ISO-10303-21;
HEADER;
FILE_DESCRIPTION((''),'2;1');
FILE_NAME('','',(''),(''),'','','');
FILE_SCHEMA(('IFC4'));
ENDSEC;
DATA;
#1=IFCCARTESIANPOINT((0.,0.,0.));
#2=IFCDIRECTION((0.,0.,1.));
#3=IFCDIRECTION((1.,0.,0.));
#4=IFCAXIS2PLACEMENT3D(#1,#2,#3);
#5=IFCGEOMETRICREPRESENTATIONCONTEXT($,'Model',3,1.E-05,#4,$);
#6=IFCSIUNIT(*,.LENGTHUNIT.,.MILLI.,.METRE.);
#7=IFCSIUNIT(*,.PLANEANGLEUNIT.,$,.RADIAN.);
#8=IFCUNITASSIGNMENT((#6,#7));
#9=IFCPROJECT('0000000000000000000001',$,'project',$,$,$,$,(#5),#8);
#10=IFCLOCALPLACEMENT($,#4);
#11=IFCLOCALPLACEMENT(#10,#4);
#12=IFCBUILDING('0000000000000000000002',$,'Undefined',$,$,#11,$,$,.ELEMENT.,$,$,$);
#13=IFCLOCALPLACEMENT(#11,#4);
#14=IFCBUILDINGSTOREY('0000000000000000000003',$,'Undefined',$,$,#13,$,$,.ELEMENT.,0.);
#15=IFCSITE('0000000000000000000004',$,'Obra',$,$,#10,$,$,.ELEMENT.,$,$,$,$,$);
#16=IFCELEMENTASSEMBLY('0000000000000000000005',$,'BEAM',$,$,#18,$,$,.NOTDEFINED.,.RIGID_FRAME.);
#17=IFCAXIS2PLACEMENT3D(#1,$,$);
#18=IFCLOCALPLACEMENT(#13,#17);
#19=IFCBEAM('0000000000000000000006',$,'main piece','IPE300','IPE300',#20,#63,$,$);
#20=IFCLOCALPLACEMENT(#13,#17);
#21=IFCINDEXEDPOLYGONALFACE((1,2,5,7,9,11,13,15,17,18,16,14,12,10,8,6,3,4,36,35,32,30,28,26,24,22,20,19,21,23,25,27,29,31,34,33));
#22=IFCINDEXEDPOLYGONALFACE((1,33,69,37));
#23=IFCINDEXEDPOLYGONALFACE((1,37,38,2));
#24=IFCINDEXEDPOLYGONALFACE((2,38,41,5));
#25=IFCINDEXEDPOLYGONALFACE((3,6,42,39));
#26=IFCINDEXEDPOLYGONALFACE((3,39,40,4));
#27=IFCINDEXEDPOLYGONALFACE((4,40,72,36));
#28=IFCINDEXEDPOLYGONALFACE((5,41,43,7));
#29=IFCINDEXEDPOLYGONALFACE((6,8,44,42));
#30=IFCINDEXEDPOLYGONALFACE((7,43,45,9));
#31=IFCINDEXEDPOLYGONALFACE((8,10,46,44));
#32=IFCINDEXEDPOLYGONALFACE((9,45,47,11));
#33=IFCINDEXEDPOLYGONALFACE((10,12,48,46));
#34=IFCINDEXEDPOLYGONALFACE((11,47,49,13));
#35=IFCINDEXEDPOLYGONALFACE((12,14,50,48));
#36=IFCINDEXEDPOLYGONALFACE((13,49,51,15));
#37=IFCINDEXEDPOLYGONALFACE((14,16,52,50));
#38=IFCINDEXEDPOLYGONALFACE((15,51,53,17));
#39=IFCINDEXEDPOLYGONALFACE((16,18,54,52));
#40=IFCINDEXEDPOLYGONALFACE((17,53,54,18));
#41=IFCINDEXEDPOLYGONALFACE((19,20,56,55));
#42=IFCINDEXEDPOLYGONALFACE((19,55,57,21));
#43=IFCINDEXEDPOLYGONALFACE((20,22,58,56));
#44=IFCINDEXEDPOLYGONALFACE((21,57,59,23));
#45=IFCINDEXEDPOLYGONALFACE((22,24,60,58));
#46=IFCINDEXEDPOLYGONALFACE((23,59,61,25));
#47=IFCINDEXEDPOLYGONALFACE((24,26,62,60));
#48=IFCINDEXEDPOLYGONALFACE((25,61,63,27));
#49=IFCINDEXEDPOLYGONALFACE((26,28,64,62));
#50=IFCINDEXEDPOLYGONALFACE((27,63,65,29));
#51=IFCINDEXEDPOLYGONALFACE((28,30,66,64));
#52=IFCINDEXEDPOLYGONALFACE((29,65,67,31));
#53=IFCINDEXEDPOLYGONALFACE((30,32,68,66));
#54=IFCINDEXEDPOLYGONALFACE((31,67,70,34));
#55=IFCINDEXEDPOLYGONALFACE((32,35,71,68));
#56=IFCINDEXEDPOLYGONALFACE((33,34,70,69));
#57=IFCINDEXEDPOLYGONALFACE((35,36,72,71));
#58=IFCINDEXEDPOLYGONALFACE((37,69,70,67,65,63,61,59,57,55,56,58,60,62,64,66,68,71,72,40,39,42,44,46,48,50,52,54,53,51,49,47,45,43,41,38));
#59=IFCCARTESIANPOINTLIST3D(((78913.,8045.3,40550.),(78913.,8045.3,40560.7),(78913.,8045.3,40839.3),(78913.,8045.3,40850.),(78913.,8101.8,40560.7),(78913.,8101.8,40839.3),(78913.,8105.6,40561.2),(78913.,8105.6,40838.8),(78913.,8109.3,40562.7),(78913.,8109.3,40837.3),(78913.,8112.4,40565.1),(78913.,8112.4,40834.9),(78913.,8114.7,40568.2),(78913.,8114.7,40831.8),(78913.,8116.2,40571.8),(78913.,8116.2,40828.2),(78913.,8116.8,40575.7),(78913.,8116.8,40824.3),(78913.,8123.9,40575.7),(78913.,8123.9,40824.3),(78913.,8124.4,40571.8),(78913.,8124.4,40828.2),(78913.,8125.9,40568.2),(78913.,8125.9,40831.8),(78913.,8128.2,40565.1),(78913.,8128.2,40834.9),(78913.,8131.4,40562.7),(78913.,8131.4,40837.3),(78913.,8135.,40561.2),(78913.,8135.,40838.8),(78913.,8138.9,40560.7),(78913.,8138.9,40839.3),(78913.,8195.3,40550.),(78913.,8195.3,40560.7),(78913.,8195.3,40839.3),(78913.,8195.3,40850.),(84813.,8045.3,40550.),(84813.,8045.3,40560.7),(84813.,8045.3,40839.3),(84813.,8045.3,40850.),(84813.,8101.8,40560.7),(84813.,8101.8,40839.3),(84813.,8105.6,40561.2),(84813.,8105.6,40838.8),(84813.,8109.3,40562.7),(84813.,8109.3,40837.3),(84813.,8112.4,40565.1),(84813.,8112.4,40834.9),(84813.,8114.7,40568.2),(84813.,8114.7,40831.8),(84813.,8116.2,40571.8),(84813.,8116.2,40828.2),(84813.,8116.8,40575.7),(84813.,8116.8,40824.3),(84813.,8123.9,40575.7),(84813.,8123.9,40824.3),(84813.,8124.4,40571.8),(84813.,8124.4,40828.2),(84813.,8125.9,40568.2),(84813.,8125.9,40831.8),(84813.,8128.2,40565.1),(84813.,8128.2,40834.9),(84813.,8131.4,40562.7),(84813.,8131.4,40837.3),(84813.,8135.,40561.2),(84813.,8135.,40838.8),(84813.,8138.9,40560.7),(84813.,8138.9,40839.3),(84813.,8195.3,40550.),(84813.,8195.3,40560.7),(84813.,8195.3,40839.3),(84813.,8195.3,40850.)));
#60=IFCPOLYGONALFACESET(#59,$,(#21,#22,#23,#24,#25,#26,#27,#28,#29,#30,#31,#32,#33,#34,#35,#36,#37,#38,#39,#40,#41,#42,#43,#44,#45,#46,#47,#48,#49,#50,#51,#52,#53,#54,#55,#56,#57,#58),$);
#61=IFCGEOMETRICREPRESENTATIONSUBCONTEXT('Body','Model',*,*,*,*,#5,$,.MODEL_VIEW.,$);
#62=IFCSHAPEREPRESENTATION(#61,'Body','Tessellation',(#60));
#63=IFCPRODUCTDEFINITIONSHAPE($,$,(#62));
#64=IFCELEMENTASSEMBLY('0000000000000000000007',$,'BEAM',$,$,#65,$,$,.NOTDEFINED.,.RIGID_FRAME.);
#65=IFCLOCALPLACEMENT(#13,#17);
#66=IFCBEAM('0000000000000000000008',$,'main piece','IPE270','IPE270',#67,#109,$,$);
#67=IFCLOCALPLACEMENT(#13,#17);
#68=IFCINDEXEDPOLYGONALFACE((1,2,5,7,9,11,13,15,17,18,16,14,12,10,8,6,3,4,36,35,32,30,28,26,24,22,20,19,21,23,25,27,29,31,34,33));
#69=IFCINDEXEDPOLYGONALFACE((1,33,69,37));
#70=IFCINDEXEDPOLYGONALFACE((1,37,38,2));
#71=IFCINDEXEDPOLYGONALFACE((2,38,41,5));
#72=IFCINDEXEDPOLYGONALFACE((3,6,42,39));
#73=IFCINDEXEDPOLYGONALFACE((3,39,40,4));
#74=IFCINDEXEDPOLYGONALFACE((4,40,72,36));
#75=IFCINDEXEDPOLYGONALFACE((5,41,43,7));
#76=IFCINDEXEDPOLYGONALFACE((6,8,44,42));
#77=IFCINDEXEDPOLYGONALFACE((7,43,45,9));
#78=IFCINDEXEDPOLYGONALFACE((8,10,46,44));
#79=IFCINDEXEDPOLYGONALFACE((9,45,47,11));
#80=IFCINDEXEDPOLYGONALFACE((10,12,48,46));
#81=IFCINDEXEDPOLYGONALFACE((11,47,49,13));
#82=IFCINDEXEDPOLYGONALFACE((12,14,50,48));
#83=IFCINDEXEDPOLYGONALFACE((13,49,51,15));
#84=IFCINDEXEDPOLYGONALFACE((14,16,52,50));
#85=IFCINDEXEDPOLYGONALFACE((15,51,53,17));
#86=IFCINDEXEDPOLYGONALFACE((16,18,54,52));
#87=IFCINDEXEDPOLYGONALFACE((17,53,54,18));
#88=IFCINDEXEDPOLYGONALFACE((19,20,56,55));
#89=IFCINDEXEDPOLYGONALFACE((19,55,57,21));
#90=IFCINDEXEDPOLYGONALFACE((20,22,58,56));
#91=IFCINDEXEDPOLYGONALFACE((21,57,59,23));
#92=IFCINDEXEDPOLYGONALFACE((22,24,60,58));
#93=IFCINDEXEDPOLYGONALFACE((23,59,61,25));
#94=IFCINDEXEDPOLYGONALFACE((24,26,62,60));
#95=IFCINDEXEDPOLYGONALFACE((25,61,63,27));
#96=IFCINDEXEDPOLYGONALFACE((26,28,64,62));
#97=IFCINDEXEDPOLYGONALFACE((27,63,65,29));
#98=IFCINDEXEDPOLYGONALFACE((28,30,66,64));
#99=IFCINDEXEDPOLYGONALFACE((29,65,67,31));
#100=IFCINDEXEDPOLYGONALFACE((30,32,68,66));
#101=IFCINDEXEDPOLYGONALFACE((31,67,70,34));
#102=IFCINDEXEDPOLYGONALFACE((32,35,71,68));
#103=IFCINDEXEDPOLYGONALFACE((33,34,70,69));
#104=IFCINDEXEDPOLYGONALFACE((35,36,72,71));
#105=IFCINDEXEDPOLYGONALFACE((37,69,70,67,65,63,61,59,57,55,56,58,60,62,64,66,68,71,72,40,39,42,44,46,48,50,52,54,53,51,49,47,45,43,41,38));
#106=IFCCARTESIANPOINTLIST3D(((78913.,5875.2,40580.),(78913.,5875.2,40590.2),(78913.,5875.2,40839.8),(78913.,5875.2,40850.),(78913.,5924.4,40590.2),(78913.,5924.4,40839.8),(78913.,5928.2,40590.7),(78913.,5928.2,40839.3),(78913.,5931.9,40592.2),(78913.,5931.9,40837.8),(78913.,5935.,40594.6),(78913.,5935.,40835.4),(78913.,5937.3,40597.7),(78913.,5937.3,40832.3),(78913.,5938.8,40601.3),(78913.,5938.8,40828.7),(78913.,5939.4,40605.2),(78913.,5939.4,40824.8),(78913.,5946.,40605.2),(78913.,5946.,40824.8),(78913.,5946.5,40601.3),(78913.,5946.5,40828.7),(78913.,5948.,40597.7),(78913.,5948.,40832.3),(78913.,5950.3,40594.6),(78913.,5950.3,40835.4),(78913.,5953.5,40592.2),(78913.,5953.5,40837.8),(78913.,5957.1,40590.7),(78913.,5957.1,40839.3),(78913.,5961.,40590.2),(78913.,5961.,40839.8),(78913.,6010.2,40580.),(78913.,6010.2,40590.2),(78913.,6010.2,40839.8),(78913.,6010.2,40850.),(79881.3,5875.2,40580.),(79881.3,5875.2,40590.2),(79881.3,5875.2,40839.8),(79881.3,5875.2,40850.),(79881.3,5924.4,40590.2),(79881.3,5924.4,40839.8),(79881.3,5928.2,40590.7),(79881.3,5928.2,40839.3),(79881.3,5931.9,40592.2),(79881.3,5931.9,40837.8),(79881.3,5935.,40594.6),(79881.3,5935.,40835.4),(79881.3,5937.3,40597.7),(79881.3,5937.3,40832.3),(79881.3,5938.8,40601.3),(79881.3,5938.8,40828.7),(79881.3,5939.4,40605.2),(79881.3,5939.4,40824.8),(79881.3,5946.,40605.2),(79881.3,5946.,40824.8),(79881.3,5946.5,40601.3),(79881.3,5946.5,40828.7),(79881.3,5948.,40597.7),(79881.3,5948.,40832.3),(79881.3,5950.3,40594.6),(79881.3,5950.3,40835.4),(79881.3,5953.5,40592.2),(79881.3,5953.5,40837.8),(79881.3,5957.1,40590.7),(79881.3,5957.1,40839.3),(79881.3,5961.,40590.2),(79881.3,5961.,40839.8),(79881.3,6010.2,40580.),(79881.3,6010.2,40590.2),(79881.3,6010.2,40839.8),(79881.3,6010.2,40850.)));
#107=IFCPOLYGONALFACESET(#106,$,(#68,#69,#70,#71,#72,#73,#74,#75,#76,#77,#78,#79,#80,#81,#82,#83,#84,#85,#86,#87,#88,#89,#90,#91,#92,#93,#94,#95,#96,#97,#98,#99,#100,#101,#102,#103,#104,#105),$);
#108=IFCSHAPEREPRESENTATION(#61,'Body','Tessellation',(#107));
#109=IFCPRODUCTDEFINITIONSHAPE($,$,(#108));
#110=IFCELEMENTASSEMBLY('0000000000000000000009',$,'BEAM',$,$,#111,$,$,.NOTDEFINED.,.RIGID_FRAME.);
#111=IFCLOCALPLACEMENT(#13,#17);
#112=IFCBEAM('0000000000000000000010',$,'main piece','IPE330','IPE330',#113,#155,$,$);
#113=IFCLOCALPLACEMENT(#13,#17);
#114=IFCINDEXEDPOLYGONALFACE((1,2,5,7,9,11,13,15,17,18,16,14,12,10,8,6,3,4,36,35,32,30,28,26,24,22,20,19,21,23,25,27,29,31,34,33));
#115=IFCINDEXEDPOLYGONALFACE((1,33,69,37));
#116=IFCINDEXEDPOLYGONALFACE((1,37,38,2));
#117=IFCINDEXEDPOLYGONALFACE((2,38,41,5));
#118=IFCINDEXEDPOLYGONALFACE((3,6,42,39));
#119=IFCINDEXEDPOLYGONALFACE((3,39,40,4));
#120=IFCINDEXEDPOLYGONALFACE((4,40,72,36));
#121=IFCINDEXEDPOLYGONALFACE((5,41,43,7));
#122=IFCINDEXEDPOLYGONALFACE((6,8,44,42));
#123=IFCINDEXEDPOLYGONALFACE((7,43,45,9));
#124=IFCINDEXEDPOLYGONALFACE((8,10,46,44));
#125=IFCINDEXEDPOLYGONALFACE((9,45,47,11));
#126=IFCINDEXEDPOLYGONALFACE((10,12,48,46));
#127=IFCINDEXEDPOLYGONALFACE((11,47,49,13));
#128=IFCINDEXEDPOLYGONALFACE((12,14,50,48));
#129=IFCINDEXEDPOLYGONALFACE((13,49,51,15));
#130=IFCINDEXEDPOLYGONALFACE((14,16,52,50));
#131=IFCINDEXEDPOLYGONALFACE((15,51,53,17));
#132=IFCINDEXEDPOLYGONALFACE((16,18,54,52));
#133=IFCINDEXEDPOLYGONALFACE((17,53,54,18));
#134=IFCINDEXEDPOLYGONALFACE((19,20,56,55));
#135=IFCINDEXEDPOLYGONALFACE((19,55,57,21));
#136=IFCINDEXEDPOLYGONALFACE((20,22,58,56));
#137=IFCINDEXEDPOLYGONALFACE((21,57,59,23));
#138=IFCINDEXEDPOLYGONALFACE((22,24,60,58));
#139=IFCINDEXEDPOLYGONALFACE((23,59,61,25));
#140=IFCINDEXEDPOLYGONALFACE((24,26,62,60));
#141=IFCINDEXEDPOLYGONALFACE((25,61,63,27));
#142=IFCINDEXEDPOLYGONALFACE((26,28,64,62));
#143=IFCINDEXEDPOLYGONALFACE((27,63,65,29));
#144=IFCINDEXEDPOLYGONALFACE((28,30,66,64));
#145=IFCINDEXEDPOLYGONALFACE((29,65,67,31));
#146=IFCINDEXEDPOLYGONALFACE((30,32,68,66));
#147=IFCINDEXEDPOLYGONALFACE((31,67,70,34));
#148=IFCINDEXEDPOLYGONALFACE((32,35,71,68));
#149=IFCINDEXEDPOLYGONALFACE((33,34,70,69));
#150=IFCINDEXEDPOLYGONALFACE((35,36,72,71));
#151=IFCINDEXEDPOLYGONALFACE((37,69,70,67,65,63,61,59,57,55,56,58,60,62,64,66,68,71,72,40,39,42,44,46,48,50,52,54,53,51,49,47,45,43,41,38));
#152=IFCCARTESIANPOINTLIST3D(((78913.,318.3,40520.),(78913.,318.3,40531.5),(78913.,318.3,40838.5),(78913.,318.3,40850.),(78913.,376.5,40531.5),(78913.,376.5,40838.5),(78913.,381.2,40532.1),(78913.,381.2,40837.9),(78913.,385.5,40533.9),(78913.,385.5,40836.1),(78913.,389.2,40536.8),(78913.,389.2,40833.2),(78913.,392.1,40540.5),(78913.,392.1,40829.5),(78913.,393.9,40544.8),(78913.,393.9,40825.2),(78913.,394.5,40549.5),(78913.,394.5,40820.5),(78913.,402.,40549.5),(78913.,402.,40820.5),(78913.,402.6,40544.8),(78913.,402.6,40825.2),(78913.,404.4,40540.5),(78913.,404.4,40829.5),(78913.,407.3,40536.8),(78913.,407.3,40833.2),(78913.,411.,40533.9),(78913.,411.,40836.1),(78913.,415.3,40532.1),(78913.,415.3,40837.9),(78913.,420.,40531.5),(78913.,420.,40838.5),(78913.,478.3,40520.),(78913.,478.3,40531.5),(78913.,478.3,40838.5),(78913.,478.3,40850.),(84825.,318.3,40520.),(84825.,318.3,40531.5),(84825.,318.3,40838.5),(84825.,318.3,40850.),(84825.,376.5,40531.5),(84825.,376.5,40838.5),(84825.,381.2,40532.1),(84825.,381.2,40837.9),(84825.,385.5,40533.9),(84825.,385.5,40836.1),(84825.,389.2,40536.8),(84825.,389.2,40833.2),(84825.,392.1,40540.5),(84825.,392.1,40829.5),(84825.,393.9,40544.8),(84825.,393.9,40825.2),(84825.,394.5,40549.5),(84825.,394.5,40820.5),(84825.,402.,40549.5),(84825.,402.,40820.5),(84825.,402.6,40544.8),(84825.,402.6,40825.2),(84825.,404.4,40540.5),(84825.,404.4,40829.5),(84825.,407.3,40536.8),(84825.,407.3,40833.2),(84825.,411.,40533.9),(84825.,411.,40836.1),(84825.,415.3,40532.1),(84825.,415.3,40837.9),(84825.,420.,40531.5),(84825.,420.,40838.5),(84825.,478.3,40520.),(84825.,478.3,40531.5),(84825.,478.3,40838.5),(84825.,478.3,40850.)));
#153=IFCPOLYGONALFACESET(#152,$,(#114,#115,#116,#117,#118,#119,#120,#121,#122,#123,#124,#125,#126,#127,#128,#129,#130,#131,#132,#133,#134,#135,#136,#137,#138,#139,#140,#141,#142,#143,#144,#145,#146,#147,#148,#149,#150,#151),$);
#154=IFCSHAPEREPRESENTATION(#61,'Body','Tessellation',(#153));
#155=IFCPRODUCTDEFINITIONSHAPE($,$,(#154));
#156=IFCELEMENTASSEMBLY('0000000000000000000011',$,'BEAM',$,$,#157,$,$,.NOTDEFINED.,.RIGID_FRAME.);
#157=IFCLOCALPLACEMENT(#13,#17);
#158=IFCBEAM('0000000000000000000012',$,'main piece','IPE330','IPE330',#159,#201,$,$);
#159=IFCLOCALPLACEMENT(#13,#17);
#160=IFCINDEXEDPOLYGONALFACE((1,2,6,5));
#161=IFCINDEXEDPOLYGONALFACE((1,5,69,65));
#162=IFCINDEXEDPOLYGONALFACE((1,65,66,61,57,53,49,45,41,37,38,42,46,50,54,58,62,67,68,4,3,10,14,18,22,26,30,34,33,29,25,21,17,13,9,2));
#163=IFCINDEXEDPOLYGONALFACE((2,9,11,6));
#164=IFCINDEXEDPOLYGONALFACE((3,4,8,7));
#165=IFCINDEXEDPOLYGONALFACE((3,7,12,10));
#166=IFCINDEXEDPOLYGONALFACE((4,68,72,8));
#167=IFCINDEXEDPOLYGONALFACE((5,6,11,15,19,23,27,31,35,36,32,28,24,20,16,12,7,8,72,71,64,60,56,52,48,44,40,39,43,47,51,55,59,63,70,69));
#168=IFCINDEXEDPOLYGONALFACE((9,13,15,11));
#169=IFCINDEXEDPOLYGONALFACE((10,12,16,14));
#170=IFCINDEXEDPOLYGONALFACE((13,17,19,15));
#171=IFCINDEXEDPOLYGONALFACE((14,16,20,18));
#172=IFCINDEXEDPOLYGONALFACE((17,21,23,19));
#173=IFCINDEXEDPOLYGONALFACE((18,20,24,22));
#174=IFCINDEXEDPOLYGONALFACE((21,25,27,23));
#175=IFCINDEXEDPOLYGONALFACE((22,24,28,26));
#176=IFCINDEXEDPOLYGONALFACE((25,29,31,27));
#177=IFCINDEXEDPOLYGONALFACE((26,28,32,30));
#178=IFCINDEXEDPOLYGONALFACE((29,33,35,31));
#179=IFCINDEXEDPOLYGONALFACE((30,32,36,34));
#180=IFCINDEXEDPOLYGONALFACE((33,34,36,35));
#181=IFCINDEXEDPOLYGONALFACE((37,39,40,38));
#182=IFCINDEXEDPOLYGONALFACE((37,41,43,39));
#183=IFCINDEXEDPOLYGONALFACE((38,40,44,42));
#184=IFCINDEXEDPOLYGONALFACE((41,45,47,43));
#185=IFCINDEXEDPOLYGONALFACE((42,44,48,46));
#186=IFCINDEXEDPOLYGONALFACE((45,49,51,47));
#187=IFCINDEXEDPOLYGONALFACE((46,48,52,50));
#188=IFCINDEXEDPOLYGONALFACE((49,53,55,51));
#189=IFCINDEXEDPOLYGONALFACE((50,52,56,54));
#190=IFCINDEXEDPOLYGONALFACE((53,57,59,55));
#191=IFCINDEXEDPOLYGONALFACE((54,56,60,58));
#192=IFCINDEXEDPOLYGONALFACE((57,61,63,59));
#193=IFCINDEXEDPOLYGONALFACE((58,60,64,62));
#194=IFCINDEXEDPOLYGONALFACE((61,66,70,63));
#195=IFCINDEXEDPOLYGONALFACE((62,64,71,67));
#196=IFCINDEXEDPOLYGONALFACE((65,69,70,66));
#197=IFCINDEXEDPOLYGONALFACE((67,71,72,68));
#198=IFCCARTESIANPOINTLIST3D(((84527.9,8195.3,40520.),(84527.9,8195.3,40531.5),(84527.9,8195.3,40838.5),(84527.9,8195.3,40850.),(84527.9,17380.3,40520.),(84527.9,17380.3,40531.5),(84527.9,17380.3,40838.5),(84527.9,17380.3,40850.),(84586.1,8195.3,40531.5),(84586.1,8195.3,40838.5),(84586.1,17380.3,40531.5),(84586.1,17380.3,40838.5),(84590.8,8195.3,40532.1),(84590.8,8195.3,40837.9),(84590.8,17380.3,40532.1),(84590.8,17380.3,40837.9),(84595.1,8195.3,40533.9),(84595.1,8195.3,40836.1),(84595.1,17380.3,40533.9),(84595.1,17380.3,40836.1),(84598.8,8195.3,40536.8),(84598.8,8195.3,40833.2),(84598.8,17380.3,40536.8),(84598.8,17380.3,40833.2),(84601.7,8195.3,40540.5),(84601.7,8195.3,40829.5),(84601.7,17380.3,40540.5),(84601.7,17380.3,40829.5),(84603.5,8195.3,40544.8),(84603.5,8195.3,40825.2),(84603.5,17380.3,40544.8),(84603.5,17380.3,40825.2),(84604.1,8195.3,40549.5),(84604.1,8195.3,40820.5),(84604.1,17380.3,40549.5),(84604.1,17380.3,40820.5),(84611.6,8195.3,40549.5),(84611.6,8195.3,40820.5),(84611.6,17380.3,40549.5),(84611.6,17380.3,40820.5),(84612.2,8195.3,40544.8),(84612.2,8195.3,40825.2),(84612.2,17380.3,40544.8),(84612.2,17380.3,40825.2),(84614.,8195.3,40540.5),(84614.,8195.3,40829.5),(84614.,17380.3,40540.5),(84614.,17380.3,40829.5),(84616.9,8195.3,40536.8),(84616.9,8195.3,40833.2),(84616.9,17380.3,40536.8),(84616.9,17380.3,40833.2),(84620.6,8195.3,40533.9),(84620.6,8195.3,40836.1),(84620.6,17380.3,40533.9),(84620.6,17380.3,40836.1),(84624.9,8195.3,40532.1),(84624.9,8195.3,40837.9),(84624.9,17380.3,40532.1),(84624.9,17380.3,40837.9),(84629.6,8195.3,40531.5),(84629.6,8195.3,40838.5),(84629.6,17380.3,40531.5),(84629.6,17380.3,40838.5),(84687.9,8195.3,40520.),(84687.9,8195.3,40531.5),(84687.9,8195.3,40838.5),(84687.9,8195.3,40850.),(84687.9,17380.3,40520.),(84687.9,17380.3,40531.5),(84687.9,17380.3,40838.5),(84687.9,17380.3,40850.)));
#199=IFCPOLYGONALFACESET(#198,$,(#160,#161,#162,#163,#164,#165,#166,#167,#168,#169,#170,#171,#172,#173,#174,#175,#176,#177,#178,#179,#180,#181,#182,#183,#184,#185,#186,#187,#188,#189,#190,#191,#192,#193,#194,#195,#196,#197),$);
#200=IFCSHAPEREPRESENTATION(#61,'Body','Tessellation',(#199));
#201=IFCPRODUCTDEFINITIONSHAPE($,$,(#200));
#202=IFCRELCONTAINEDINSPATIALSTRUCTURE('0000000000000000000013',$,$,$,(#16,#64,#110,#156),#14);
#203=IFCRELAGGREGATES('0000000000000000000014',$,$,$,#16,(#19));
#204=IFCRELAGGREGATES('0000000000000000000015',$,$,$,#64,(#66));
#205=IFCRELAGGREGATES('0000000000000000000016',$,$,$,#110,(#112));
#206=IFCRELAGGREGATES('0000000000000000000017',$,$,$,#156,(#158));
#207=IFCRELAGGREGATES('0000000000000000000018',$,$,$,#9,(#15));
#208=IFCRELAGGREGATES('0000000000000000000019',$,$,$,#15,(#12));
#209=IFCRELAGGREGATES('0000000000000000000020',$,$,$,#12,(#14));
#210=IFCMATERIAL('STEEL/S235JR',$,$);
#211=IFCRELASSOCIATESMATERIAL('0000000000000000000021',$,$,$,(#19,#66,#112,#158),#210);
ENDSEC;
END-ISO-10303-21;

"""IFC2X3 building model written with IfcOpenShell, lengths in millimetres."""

from ifc_helpers import new_model, si_unit, frame, origin_with_axes, origin_2d_with_axis, place, context, subcontext, project, spatial, i_section, extrude, material, element, aggregate, save


model = new_model("IFC2X3")

# Units and contexts
model_context = context("Model", 3, precision=1e-05, world=origin_with_axes())
body_context = subcontext(model_context, "Body", "Model", "MODEL_VIEW")
ifc_project = project(units=[si_unit("LENGTHUNIT", "METRE", prefix="MILLI"), si_unit("PLANEANGLEUNIT", "RADIAN")], contexts=[model_context])

# Site, building, storey
site_placement = place(None, origin_with_axes())
site = spatial("IfcSite", under=ifc_project, at=site_placement, Name="Obra", CompositionType="ELEMENT")
building_placement = place(site_placement, origin_with_axes())
building = spatial("IfcBuilding", under=site, at=building_placement, Name="Undefined", CompositionType="ELEMENT")
storey_placement = place(building_placement, origin_with_axes())
storey = spatial("IfcBuildingStorey", under=building, at=storey_placement, Name="Undefined", CompositionType="ELEMENT", Elevation=0.0)

# Shared definitions
ifc_material_1 = material(Name="STEEL/S235JR")

# Element assemblies, beams
assembly_1_placement = place(storey_placement, origin_with_axes())
assembly_1 = element("IfcElementAssembly", 1, at=assembly_1_placement, inside=storey, Name="BEAM", AssemblyPlace="NOTDEFINED", PredefinedType="RIGID_FRAME")
beam_1_placement = place(assembly_1_placement, frame((78913.0, 8120.3, 40700.0), z_axis=(0.0, 0.0, 1.0), x_axis=(1.0, 0.0, 0.0)))
beam_1 = element("IfcBeam", 2, at=beam_1_placement, material=ifc_material_1, Name="main piece", Description="IPE300", ObjectType="IPE300", context=body_context, shape_type="SweptSolid", body=[
    extrude(i_section(OverallWidth=150.0, OverallDepth=300.0, WebThickness=7.1, FlangeThickness=10.7, FilletRadius=15.0, at=origin_2d_with_axis()), frame((5900.0, 0.0, 0.0), z_axis=(-1.0, 0.0, 0.0), x_axis=(0.0, -1.0, 0.0)), (0.0, 0.0, 1.0), 5900.0),
])
aggregate(assembly_1, [beam_1])
assembly_2_placement = place(storey_placement, origin_with_axes())
assembly_2 = element("IfcElementAssembly", 3, at=assembly_2_placement, inside=storey, Name="BEAM", AssemblyPlace="NOTDEFINED", PredefinedType="RIGID_FRAME")
beam_2_placement = place(assembly_2_placement, frame((78913.0, 5942.7, 40715.0), z_axis=(0.0, 0.0, 1.0), x_axis=(1.0, 0.0, 0.0)))
beam_2 = element("IfcBeam", 4, at=beam_2_placement, material=ifc_material_1, Name="main piece", Description="IPE270", ObjectType="IPE270", context=body_context, shape_type="SweptSolid", body=[
    extrude(i_section(OverallWidth=135.0, OverallDepth=270.0, WebThickness=6.6, FlangeThickness=10.2, FilletRadius=15.0, at=origin_2d_with_axis()), frame((968.3, 0.0, 0.0), z_axis=(-1.0, 0.0, 0.0), x_axis=(0.0, -1.0, 0.0)), (0.0, 0.0, 1.0), 968.3),
])
aggregate(assembly_2, [beam_2])
assembly_3_placement = place(storey_placement, origin_with_axes())
assembly_3 = element("IfcElementAssembly", 5, at=assembly_3_placement, inside=storey, Name="BEAM", AssemblyPlace="NOTDEFINED", PredefinedType="RIGID_FRAME")
beam_3_placement = place(assembly_3_placement, frame((78913.0, 398.3, 40685.0), z_axis=(0.0, 0.0, 1.0), x_axis=(1.0, 0.0, 0.0)))
beam_3 = element("IfcBeam", 6, at=beam_3_placement, material=ifc_material_1, Name="main piece", Description="IPE330", ObjectType="IPE330", context=body_context, shape_type="SweptSolid", body=[
    extrude(i_section(OverallWidth=160.0, OverallDepth=330.0, WebThickness=7.5, FlangeThickness=11.5, FilletRadius=18.0, at=origin_2d_with_axis()), frame((5912.0, 0.0, 0.0), z_axis=(-1.0, 0.0, 0.0), x_axis=(0.0, -1.0, 0.0)), (0.0, 0.0, 1.0), 5912.0),
])
aggregate(assembly_3, [beam_3])
assembly_4_placement = place(storey_placement, origin_with_axes())
assembly_4 = element("IfcElementAssembly", 7, at=assembly_4_placement, inside=storey, Name="BEAM", AssemblyPlace="NOTDEFINED", PredefinedType="RIGID_FRAME")
beam_4_placement = place(assembly_4_placement, frame((84607.9, 8195.3, 40685.0), z_axis=(0.0, 0.0, 1.0), x_axis=(0.0, 1.0, 0.0)))
beam_4 = element("IfcBeam", 8, at=beam_4_placement, material=ifc_material_1, Name="main piece", Description="IPE330", ObjectType="IPE330", context=body_context, shape_type="SweptSolid", body=[
    extrude(i_section(OverallWidth=160.0, OverallDepth=330.0, WebThickness=7.5, FlangeThickness=11.5, FilletRadius=18.0, at=origin_2d_with_axis()), frame((9185.0, 0.0, 0.0), z_axis=(-1.0, 0.0, 0.0), x_axis=(0.0, -1.0, 0.0)), (0.0, 0.0, 1.0), 9185.0),
])
aggregate(assembly_4, [beam_4])

save(model, "model.ifc")
